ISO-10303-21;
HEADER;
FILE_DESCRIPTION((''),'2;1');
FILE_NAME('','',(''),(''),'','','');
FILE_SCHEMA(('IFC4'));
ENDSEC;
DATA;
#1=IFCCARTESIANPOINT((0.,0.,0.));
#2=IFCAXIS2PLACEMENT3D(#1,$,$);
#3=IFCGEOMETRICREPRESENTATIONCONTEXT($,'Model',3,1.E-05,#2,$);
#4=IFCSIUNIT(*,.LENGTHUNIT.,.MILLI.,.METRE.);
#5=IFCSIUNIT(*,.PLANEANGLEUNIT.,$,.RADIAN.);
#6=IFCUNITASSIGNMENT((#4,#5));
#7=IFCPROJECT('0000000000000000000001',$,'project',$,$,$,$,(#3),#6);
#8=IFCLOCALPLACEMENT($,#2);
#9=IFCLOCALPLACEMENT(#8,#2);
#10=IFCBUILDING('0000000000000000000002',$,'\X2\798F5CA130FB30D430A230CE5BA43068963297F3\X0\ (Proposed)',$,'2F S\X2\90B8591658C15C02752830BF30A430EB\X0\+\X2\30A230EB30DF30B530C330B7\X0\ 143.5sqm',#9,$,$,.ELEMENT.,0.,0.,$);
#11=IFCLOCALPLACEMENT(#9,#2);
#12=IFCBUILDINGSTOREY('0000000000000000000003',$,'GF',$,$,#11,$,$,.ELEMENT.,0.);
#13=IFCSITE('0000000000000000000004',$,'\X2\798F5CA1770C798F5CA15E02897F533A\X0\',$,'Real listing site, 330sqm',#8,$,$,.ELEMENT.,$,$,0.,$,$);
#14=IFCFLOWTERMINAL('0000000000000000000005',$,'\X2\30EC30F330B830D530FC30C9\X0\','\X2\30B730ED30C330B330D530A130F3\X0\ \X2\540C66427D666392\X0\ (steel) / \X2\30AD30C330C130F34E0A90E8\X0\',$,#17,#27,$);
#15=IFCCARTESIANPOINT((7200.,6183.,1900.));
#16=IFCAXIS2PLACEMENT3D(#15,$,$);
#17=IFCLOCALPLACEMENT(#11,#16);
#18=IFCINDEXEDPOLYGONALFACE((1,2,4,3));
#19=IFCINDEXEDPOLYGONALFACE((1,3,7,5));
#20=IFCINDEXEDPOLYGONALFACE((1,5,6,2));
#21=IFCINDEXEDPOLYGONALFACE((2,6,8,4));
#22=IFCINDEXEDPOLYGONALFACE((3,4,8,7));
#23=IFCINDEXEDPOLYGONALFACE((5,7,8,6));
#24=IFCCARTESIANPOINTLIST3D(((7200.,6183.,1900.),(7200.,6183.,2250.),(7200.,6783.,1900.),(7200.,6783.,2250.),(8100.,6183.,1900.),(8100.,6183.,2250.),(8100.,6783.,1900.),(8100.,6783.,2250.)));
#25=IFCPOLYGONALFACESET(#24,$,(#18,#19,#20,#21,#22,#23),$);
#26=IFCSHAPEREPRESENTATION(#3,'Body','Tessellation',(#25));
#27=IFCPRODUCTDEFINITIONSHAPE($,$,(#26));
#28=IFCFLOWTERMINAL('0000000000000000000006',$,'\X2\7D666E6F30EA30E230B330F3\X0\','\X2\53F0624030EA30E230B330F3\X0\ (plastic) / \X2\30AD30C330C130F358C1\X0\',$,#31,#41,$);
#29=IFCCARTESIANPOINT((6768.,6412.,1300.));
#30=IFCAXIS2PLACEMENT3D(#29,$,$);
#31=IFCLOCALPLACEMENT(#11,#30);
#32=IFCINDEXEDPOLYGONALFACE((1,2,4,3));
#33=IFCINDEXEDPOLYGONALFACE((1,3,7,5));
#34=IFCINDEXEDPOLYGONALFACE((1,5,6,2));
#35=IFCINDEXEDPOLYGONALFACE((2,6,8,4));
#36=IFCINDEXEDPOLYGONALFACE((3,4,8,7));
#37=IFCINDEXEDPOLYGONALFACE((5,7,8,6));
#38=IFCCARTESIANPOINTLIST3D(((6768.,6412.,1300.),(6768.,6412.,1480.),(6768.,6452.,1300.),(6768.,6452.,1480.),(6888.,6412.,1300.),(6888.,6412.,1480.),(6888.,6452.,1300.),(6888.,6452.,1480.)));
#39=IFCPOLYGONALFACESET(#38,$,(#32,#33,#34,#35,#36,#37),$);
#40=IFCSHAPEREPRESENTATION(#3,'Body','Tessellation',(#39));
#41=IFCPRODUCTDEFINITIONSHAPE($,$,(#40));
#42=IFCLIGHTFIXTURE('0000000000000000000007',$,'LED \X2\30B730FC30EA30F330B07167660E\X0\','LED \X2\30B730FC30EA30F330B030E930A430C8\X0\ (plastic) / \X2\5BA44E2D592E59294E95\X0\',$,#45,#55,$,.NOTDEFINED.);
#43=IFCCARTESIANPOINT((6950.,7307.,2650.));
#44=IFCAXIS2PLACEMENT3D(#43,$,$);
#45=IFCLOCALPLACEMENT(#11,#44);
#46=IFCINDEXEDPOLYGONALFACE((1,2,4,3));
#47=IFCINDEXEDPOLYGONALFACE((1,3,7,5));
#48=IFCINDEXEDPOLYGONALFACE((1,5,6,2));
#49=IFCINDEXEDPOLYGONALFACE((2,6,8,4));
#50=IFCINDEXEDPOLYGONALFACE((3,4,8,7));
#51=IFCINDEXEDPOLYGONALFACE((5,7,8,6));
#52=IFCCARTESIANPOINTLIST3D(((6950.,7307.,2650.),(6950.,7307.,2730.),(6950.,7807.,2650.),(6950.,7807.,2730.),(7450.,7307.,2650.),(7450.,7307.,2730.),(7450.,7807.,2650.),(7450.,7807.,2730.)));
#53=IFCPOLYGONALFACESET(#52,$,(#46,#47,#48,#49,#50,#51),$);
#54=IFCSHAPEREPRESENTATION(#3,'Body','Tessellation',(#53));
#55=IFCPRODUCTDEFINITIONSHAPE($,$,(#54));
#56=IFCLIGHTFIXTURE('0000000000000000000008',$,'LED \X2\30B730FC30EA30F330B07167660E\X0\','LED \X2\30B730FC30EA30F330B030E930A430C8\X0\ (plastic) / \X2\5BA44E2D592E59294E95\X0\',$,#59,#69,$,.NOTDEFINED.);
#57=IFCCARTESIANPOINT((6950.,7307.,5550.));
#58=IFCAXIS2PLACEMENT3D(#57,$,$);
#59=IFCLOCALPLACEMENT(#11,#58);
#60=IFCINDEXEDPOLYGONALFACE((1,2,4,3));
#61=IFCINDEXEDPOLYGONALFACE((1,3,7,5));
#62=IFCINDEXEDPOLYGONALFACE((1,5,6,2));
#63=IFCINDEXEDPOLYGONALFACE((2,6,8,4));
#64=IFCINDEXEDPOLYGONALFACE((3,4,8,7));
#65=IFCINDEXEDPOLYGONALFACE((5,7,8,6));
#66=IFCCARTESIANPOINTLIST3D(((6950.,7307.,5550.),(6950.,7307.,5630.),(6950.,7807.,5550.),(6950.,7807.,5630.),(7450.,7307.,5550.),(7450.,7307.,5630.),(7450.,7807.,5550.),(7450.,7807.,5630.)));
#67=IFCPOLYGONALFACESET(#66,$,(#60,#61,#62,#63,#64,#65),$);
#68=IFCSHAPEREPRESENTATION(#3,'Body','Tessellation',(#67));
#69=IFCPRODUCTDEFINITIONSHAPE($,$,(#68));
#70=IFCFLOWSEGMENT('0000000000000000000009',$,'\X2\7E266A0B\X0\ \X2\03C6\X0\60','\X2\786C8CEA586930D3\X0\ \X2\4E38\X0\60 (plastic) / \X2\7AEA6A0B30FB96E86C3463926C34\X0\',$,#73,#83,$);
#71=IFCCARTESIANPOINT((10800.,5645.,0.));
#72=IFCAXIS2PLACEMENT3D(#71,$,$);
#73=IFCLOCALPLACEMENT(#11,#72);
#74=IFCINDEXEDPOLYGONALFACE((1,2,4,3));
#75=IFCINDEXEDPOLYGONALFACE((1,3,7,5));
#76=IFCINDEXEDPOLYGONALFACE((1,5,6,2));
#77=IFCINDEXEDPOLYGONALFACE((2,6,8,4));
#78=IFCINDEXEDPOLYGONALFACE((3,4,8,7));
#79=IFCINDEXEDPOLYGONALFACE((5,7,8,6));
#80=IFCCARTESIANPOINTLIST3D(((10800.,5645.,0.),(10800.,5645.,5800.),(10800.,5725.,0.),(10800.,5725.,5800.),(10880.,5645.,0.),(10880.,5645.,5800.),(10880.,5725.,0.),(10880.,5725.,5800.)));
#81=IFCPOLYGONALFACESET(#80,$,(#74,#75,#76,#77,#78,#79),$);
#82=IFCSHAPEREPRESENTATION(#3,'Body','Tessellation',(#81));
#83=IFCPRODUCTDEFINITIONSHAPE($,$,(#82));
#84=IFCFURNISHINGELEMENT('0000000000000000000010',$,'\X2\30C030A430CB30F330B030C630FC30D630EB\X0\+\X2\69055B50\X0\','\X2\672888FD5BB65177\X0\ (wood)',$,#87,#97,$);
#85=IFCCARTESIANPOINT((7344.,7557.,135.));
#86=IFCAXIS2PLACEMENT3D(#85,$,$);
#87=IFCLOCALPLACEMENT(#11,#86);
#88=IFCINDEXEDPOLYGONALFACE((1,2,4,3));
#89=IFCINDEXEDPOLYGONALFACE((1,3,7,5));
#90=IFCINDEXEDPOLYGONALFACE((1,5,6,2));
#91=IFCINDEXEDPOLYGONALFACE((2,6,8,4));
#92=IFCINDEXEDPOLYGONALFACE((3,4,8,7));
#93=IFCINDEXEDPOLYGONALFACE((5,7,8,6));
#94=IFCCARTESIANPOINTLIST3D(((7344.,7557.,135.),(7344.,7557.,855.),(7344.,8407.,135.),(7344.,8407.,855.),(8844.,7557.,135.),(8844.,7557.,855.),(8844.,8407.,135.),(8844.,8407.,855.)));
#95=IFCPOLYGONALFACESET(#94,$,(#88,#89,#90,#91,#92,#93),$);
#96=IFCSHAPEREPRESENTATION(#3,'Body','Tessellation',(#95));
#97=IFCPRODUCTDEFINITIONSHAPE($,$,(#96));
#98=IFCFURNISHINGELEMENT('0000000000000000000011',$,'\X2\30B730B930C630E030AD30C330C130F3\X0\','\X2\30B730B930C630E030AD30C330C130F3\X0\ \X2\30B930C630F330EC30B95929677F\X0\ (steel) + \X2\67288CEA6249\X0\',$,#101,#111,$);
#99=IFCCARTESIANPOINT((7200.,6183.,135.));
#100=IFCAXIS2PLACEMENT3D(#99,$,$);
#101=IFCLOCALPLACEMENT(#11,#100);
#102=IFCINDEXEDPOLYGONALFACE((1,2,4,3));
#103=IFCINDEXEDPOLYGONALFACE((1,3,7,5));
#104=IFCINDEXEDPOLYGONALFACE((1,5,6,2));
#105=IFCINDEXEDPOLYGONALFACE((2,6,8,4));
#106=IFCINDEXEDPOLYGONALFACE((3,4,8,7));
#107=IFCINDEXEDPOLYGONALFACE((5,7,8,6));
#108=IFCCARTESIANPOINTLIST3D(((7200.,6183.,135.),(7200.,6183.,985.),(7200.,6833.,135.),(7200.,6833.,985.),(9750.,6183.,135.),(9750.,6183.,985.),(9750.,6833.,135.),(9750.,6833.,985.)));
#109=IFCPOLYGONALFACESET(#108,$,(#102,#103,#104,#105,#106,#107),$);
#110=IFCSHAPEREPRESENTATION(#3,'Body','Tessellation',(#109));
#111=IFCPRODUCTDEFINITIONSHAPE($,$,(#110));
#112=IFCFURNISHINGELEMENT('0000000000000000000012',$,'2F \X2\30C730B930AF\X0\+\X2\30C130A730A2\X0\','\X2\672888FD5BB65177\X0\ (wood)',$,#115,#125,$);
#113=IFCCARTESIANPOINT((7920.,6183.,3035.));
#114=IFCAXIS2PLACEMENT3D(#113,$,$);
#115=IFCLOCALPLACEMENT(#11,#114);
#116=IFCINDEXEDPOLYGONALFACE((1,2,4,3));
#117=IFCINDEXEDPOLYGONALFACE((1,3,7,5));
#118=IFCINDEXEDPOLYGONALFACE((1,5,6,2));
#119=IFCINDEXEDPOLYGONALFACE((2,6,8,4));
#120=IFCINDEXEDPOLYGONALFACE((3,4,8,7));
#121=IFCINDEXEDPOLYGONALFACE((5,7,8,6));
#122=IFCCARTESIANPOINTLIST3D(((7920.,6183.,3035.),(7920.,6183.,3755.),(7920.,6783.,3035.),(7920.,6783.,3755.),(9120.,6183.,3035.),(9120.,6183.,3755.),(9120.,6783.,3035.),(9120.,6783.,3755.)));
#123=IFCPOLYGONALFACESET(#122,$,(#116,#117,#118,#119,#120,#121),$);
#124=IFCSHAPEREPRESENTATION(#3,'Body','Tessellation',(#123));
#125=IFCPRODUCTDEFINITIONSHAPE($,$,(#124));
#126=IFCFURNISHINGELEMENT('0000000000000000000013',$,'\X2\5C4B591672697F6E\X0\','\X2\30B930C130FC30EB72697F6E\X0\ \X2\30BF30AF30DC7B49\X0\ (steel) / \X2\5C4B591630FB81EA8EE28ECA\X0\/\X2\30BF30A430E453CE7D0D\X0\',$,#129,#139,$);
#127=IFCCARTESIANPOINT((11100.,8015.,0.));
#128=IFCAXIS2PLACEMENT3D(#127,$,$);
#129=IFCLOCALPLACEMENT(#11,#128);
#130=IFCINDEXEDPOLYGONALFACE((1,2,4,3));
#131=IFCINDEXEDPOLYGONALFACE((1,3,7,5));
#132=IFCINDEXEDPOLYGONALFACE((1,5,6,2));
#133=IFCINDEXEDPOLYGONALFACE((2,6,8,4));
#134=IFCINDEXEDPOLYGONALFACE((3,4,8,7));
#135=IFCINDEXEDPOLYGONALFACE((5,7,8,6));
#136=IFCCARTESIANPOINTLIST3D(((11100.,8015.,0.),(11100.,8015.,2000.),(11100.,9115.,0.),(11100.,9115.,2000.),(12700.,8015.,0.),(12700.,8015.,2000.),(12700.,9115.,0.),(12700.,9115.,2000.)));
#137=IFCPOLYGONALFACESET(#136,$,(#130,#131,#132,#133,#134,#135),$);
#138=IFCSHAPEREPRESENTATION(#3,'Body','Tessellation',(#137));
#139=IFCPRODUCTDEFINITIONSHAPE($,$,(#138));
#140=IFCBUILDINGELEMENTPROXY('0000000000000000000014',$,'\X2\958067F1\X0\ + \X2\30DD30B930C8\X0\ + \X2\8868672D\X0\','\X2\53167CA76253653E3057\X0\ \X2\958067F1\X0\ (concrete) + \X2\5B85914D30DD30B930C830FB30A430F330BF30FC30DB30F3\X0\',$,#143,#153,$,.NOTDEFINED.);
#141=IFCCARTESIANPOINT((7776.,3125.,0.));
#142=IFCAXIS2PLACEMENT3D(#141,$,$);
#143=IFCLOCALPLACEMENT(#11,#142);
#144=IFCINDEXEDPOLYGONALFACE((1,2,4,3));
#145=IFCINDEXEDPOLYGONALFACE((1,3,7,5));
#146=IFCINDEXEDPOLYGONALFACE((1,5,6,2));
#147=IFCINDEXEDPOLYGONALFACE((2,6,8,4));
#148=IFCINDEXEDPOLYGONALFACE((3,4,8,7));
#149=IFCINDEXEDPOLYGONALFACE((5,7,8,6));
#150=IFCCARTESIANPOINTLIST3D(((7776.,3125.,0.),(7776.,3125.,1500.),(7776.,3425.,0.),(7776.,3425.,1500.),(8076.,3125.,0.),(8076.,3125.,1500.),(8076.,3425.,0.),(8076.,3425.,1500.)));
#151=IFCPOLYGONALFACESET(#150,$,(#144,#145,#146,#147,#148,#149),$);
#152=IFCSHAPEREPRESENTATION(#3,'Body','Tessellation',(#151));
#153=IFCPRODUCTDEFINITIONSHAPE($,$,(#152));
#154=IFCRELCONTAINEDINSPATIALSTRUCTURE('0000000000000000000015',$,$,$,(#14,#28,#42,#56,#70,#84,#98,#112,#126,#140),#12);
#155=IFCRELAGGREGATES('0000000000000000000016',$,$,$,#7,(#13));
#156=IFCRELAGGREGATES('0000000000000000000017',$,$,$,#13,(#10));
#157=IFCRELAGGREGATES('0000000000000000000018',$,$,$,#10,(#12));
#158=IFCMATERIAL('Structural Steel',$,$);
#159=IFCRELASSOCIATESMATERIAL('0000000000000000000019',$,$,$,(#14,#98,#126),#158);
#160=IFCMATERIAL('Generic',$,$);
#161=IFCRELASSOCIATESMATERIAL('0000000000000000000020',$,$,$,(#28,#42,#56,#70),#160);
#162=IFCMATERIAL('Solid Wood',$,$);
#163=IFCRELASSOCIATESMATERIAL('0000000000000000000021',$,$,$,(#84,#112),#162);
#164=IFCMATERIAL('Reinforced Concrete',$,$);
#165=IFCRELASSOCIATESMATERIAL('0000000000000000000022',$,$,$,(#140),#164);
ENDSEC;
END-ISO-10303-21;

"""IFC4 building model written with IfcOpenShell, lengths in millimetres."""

from ifc_helpers import new_model, si_unit, frame, frame_2d, origin, place, context, project, spatial, rectangle, extrude, material, element, save


model = new_model("IFC4")

# Units and contexts
model_context = context("Model", 3, precision=1e-05, world=origin())
ifc_project = project(units=[si_unit("LENGTHUNIT", "METRE", prefix="MILLI"), si_unit("PLANEANGLEUNIT", "RADIAN")], contexts=[model_context])

# Site, building, storey
site_placement = place(None, origin())
site = spatial("IfcSite", under=ifc_project, at=site_placement, Name="福岡県福岡市西区", ObjectType="Real listing site, 330sqm", CompositionType="ELEMENT", RefElevation=0.0)
building_placement = place(site_placement, origin())
building = spatial("IfcBuilding", under=site, at=building_placement, Name="福岡・ピアノ室と防音 (Proposed)", ObjectType="2F S邸外壁専用タイル+アルミサッシ 143.5sqm", CompositionType="ELEMENT", ElevationOfRefHeight=0.0, ElevationOfTerrain=0.0)
storey_placement = place(building_placement, origin())
storey = spatial("IfcBuildingStorey", under=building, at=storey_placement, Name="GF", CompositionType="ELEMENT", Elevation=0.0)

# Shared definitions
ifc_material_1 = material(Name="Solid Wood")

# Shared definitions
ifc_material_2 = material(Name="Reinforced Concrete")

# Shared definitions
ifc_material_3 = material(Name="Structural Steel")

# Flow terminals
flow_terminal_1_placement = place(storey_placement, frame((7200.0, 6183.0, 1900.0)))
element("IfcFlowTerminal", 1, at=flow_terminal_1_placement, inside=storey, material=ifc_material_3, Name="レンジフード", Description="シロッコファン 同時給排 (steel) / キッチン上部", context=model_context, shape_type="SweptSolid", body=[
    extrude(rectangle(XDim=900.0, YDim=600.0, at=frame_2d((450.0, 300.0))), frame((7200.0, 6183.0, 1900.0)), (0.0, 0.0, 1.0), 350.0),
])
ifc_material_4 = material(Name="Generic")
flow_terminal_2_placement = place(storey_placement, frame((6768.0, 6412.0, 1300.0)))
element("IfcFlowTerminal", 2, at=flow_terminal_2_placement, inside=storey, material=ifc_material_4, Name="給湯リモコン", Description="台所リモコン (plastic) / キッチン壁", context=model_context, shape_type="SweptSolid", body=[
    extrude(rectangle(XDim=120.0, YDim=40.0, at=frame_2d((60.0, 20.0))), frame((6768.0, 6412.0, 1300.0)), (0.0, 0.0, 1.0), 180.0),
])

# Light fixtures
light_fixture_1_placement = place(storey_placement, frame((6950.0, 7307.0, 2650.0)))
element("IfcLightFixture", 3, at=light_fixture_1_placement, inside=storey, material=ifc_material_4, Name="LED シーリング照明", Description="LED シーリングライト (plastic) / 室中央天井", PredefinedType="NOTDEFINED", context=model_context, shape_type="SweptSolid", body=[
    extrude(rectangle(XDim=500.0, YDim=500.0, at=frame_2d((250.0, 250.0))), frame((6950.0, 7307.0, 2650.0)), (0.0, 0.0, 1.0), 80.0),
])
light_fixture_2_placement = place(storey_placement, frame((6950.0, 7307.0, 5550.0)))
element("IfcLightFixture", 4, at=light_fixture_2_placement, inside=storey, material=ifc_material_4, Name="LED シーリング照明", Description="LED シーリングライト (plastic) / 室中央天井", PredefinedType="NOTDEFINED", context=model_context, shape_type="SweptSolid", body=[
    extrude(rectangle(XDim=500.0, YDim=500.0, at=frame_2d((250.0, 250.0))), frame((6950.0, 7307.0, 5550.0)), (0.0, 0.0, 1.0), 80.0),
])

# Flow segment
flow_segment_placement = place(storey_placement, frame((10800.0, 5645.0, 0.0)))
element("IfcFlowSegment", 5, at=flow_segment_placement, inside=storey, material=ifc_material_4, Name="縦樋 φ60", Description="硬質塩ビ 丸60 (plastic) / 竪樋・雨水排水", context=model_context, shape_type="SweptSolid", body=[
    extrude(rectangle(XDim=80.0, YDim=80.0, at=frame_2d((40.0, 40.0))), frame((10800.0, 5645.0, 0.0)), (0.0, 0.0, 1.0), 5800.0),
])

# Furnishing elements
furnishing_1_placement = place(storey_placement, frame((7344.0, 7557.0, 135.0)))
element("IfcFurnishingElement", 6, at=furnishing_1_placement, inside=storey, material=ifc_material_1, Name="ダイニングテーブル+椅子", Description="木製家具 (wood)", context=model_context, shape_type="SweptSolid", body=[
    extrude(rectangle(XDim=1500.0, YDim=850.0, at=frame_2d((750.0, 425.0))), frame((7344.0, 7557.0, 135.0)), (0.0, 0.0, 1.0), 720.0),
])
furnishing_2_placement = place(storey_placement, frame((7200.0, 6183.0, 135.0)))
element("IfcFurnishingElement", 7, at=furnishing_2_placement, inside=storey, material=ifc_material_3, Name="システムキッチン", Description="システムキッチン ステンレス天板 (steel) + 木質扉", context=model_context, shape_type="SweptSolid", body=[
    extrude(rectangle(XDim=2550.0, YDim=650.0, at=frame_2d((1275.0, 325.0))), frame((7200.0, 6183.0, 135.0)), (0.0, 0.0, 1.0), 850.0),
])
furnishing_3_placement = place(storey_placement, frame((7920.0, 6183.0, 3035.0)))
element("IfcFurnishingElement", 8, at=furnishing_3_placement, inside=storey, material=ifc_material_1, Name="2F デスク+チェア", Description="木製家具 (wood)", context=model_context, shape_type="SweptSolid", body=[
    extrude(rectangle(XDim=1200.0, YDim=600.0, at=frame_2d((600.0, 300.0))), frame((7920.0, 6183.0, 3035.0)), (0.0, 0.0, 1.0), 720.0),
])
furnishing_4_placement = place(storey_placement, frame((11100.0, 8015.0, 0.0)))
element("IfcFurnishingElement", 9, at=furnishing_4_placement, inside=storey, material=ifc_material_3, Name="屋外物置", Description="スチール物置 タクボ等 (steel) / 屋外・自転車/タイヤ収納", context=model_context, shape_type="SweptSolid", body=[
    extrude(rectangle(XDim=1600.0, YDim=1100.0, at=frame_2d((800.0, 550.0))), frame((11100.0, 8015.0, 0.0)), (0.0, 0.0, 1.0), 2000.0),
])

# Building element proxy
proxy_placement = place(storey_placement, frame((7776.0, 3125.0, 0.0)))
element("IfcBuildingElementProxy", 10, at=proxy_placement, inside=storey, material=ifc_material_2, Name="門柱 + ポスト + 表札", Description="化粧打放し 門柱 (concrete) + 宅配ポスト・インターホン", PredefinedType="NOTDEFINED", context=model_context, shape_type="SweptSolid", body=[
    extrude(rectangle(XDim=300.0, YDim=300.0, at=frame_2d((150.0, 150.0))), frame((7776.0, 3125.0, 0.0)), (0.0, 0.0, 1.0), 1500.0),
])

save(model, "model.ifc")
